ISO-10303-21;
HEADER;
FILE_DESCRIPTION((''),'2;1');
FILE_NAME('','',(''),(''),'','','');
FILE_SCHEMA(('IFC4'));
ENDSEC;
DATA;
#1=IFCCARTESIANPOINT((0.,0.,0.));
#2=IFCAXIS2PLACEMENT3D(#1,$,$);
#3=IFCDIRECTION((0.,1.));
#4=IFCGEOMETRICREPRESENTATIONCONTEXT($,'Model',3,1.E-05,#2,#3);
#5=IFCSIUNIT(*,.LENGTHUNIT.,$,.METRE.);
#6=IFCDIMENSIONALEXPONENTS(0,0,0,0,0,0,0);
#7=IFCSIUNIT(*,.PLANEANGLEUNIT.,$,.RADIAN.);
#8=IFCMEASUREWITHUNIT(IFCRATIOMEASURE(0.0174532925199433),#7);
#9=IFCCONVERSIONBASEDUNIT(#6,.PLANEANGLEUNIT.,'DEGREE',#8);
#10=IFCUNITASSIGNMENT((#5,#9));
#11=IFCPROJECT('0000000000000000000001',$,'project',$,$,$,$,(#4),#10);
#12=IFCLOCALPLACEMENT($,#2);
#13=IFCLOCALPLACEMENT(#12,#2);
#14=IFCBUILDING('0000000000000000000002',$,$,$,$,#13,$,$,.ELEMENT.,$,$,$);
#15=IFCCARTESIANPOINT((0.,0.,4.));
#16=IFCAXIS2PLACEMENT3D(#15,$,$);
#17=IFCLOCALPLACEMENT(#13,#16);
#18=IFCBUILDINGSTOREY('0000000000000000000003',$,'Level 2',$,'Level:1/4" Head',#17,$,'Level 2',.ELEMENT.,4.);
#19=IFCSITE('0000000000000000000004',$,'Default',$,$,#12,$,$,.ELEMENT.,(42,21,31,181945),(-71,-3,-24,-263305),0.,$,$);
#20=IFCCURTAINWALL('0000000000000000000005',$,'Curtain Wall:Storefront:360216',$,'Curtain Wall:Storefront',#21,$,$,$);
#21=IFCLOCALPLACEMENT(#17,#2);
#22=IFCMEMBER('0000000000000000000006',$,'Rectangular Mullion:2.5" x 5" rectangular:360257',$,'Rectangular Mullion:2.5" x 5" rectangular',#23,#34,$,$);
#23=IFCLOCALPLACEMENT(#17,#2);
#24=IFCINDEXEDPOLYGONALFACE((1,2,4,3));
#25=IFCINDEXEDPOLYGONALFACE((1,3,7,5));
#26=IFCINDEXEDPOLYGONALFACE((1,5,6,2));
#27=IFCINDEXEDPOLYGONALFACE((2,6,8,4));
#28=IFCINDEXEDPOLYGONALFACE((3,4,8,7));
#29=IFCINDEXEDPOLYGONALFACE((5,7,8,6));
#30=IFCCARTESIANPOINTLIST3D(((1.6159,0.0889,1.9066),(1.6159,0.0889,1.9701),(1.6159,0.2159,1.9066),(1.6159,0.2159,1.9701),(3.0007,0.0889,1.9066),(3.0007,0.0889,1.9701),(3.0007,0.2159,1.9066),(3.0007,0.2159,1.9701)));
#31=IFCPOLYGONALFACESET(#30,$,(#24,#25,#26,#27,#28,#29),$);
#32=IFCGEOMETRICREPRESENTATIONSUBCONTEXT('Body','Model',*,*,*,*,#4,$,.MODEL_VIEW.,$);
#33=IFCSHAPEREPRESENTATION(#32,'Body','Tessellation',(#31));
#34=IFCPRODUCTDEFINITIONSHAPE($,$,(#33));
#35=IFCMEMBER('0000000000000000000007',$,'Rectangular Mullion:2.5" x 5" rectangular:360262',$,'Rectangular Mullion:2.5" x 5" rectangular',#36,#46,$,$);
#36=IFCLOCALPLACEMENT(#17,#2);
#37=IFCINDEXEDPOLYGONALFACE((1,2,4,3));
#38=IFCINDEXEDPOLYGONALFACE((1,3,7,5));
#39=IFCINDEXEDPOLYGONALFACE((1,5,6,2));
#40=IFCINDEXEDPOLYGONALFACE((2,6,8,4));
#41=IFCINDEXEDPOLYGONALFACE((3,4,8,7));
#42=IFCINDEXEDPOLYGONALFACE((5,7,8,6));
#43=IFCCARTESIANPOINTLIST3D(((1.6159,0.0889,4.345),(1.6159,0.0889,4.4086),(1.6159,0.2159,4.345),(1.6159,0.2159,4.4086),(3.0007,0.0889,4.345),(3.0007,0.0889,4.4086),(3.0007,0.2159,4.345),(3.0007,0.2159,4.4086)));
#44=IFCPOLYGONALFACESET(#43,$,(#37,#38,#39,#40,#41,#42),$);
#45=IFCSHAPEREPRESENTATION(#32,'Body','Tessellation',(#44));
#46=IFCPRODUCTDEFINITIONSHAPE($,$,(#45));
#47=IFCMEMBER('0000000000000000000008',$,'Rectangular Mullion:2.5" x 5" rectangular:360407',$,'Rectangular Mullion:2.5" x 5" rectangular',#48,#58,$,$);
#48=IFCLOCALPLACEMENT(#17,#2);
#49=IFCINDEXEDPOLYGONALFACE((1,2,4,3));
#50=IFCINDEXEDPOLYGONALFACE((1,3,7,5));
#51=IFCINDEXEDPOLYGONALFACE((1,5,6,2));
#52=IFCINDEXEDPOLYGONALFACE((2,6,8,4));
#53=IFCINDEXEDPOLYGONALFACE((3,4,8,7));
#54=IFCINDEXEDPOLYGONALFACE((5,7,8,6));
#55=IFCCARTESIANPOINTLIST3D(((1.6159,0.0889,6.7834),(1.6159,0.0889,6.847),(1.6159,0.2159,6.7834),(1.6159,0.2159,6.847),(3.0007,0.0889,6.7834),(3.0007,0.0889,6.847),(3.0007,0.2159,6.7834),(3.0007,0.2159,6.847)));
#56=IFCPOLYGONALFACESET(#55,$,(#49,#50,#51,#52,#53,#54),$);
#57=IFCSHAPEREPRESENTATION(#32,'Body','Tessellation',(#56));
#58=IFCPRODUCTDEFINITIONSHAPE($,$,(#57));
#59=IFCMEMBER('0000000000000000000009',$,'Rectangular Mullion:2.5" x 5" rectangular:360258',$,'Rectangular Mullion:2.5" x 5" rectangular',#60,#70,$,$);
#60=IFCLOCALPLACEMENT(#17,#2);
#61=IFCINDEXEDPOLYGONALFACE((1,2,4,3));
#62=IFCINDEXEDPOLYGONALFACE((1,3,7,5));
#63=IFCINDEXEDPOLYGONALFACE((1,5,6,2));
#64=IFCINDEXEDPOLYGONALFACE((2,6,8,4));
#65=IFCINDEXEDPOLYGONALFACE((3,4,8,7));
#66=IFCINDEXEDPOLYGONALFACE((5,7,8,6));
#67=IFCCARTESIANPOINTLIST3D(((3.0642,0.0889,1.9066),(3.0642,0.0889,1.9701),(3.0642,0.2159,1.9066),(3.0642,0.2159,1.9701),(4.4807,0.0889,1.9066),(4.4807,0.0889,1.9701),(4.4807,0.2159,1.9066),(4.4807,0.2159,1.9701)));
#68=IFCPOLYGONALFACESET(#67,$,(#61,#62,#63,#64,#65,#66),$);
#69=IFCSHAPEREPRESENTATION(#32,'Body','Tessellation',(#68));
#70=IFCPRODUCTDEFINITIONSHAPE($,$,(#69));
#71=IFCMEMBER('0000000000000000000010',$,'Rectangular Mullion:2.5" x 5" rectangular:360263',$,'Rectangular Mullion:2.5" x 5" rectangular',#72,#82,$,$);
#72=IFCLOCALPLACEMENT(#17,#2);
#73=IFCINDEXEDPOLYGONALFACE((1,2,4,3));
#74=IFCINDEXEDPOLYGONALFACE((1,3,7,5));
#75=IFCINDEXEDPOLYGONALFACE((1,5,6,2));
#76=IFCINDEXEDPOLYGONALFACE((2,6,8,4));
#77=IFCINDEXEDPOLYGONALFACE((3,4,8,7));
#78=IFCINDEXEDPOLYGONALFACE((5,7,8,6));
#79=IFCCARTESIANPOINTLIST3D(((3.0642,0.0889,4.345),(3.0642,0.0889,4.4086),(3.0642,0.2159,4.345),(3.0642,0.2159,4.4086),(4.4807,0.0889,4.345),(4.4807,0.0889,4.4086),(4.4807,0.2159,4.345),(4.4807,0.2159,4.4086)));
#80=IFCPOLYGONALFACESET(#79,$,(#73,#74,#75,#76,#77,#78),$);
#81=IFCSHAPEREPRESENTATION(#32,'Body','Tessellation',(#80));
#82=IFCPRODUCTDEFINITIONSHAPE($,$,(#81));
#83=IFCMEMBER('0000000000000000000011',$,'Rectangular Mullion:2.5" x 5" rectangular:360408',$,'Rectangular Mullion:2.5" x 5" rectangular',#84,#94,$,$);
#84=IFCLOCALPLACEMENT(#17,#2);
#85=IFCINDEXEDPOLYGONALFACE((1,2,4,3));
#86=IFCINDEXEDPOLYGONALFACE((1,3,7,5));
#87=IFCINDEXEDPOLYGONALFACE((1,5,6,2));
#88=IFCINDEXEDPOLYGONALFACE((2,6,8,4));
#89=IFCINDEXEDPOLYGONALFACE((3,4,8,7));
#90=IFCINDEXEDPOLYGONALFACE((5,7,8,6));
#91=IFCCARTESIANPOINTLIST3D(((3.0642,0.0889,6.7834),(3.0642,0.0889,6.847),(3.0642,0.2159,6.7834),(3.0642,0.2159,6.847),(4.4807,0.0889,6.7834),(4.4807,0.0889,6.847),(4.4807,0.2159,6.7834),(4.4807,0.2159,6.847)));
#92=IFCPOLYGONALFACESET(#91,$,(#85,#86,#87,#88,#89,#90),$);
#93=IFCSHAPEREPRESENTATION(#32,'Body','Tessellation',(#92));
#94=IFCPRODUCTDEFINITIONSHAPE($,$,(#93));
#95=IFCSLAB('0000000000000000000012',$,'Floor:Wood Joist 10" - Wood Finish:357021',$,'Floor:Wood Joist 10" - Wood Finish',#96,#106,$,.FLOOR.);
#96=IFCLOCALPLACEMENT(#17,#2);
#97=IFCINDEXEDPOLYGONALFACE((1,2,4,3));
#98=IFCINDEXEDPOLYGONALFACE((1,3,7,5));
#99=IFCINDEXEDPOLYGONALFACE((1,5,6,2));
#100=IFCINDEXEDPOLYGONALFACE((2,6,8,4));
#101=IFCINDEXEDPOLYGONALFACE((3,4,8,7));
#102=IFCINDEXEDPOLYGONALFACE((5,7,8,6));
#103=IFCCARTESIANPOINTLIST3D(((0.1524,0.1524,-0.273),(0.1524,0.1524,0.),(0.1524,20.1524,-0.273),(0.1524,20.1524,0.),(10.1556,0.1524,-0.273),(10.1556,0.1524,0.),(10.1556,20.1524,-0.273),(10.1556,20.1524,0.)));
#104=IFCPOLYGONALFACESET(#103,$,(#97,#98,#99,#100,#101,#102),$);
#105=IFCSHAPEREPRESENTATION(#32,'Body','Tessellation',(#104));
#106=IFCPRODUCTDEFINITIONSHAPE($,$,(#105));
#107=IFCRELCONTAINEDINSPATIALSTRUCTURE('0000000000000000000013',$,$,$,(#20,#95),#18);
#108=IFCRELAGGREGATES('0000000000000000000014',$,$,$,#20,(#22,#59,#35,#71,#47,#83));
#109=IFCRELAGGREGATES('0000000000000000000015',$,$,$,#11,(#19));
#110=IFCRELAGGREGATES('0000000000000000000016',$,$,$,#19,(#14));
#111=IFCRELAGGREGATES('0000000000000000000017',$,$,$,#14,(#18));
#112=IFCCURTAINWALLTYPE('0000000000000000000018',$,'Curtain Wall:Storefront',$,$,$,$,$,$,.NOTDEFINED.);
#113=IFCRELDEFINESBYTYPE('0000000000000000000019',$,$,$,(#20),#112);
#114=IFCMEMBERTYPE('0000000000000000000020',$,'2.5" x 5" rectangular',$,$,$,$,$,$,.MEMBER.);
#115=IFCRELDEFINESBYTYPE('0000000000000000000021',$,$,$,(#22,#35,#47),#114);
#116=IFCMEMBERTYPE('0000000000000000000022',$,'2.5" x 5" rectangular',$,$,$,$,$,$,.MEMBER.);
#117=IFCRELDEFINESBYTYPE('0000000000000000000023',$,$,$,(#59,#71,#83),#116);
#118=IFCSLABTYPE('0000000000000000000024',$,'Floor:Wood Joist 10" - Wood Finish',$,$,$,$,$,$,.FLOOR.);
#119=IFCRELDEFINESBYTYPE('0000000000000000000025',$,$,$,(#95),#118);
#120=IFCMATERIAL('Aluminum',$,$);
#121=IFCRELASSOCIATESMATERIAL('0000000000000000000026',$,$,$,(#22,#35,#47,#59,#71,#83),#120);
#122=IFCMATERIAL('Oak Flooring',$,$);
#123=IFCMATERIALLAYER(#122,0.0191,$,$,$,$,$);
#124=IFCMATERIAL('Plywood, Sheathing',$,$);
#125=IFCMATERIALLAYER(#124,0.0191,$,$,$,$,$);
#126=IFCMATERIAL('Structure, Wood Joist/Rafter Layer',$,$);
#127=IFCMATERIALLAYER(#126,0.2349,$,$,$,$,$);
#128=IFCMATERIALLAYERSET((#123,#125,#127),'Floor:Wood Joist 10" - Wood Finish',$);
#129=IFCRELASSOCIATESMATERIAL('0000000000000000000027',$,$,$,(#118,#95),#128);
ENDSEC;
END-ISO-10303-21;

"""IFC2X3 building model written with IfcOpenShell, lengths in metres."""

from ifc_helpers import new_model, entity, si_unit, converted_unit, direction, frame, origin, origin_2d_with_axis, place, context, subcontext, project, spatial, rectangle, extrude, source, transform, mapped, material, layer, layer_set, layer_usage, type_object, type_shapes, element, aggregate, save


model = new_model("IFC2X3")

# Units and contexts
model_context = context("Model", 3, precision=1e-05, world=origin(), true_north=direction((0.0, 1.0)))
body_context = subcontext(model_context, "Body", "Model", "MODEL_VIEW")
ifc_project = project(units=[si_unit("LENGTHUNIT", "METRE"), converted_unit("PLANEANGLEUNIT", "DEGREE", entity("IfcRatioMeasure", 0.0174532925199433), si_unit("PLANEANGLEUNIT", "RADIAN"), dimensions=[0, 0, 0, 0, 0, 0, 0])], contexts=[model_context])

# Site, building, storey
site_placement = place(None, origin())
site = spatial("IfcSite", under=ifc_project, at=site_placement, Name="Default", CompositionType="ELEMENT", RefLatitude=(42, 21, 31, 181945), RefLongitude=(-71, -3, -24, -263305), RefElevation=0.0)
building_placement = place(site_placement, origin())
building = spatial("IfcBuilding", under=site, at=building_placement, CompositionType="ELEMENT")
storey_placement = place(building_placement, frame((0.0, 0.0, 4.0)))
storey = spatial("IfcBuildingStorey", under=building, at=storey_placement, Name="Level 2", ObjectType="Level:1/4\" Head", LongName="Level 2", CompositionType="ELEMENT", Elevation=4.0)

# Curtain wall, members
curtain_wall_type = type_object("IfcCurtainWallType", Name="Curtain Wall:Storefront", PredefinedType="NOTDEFINED")
curtain_wall_placement = place(storey_placement, frame((0.0, 0.0, -4.0)))
curtain_wall = element("IfcCurtainWall", 1, at=curtain_wall_placement, inside=storey, type_object=curtain_wall_type, Name="Curtain Wall:Storefront:360216", ObjectType="Curtain Wall:Storefront")
ifc_material_1 = material(Name="Aluminum")
member_type_1 = type_object("IfcMemberType", Name="2.5\" x 5\" rectangular", PredefinedType="MEMBER")
shared_shape_1 = source(origin(), body_context, "Body", "SweptSolid", [
    extrude(rectangle(XDim=0.127, YDim=0.0635, at=origin_2d_with_axis()), frame((0.0, 0.0, -1.3848), z_axis=(0.0, 0.0, 1.0), x_axis=(0.0, -1.0, 0.0)), (0.0, 0.0, 1.0), 1.3848),
])
type_shapes(member_type_1, [shared_shape_1])
member_1_placement = place(storey_placement, frame((3.0007, 0.1524, 1.9384), z_axis=(1.0, 0.0, 0.0), x_axis=(0.0, 0.0, 1.0)))
member_1 = element("IfcMember", 2, at=member_1_placement, type_object=member_type_1, material=ifc_material_1, Name="Rectangular Mullion:2.5\" x 5\" rectangular:360257", ObjectType="Rectangular Mullion:2.5\" x 5\" rectangular", context=body_context, shape_type="MappedRepresentation", body=[
    mapped(shared_shape_1, transform((0.0, 0.0, 0.0), scale=1.0)),
])
member_2_placement = place(storey_placement, frame((3.0007, 0.1524, 4.3768), z_axis=(1.0, 0.0, 0.0), x_axis=(0.0, 0.0, 1.0)))
member_2 = element("IfcMember", 3, at=member_2_placement, type_object=member_type_1, material=ifc_material_1, Name="Rectangular Mullion:2.5\" x 5\" rectangular:360262", ObjectType="Rectangular Mullion:2.5\" x 5\" rectangular", context=body_context, shape_type="MappedRepresentation", body=[
    mapped(shared_shape_1, transform((0.0, 0.0, 0.0), scale=1.0)),
])
member_3_placement = place(storey_placement, frame((3.0007, 0.1524, 6.8152), z_axis=(1.0, 0.0, 0.0), x_axis=(0.0, 0.0, 1.0)))
member_3 = element("IfcMember", 4, at=member_3_placement, type_object=member_type_1, material=ifc_material_1, Name="Rectangular Mullion:2.5\" x 5\" rectangular:360407", ObjectType="Rectangular Mullion:2.5\" x 5\" rectangular", context=body_context, shape_type="MappedRepresentation", body=[
    mapped(shared_shape_1, transform((0.0, 0.0, 0.0), scale=1.0)),
])
member_type_2 = type_object("IfcMemberType", Name="2.5\" x 5\" rectangular", PredefinedType="MEMBER")
shared_shape_2 = source(origin(), body_context, "Body", "SweptSolid", [
    extrude(rectangle(XDim=0.127, YDim=0.0635, at=origin_2d_with_axis()), frame((0.0, 0.0, -1.4165), z_axis=(0.0, 0.0, 1.0), x_axis=(0.0, -1.0, 0.0)), (0.0, 0.0, 1.0), 1.4165),
])
type_shapes(member_type_2, [shared_shape_2])
member_4_placement = place(storey_placement, frame((4.4807, 0.1524, 1.9384), z_axis=(1.0, 0.0, 0.0), x_axis=(0.0, 0.0, 1.0)))
member_4 = element("IfcMember", 5, at=member_4_placement, type_object=member_type_2, material=ifc_material_1, Name="Rectangular Mullion:2.5\" x 5\" rectangular:360258", ObjectType="Rectangular Mullion:2.5\" x 5\" rectangular", context=body_context, shape_type="MappedRepresentation", body=[
    mapped(shared_shape_2, transform((0.0, 0.0, 0.0), scale=1.0)),
])
member_5_placement = place(storey_placement, frame((4.4807, 0.1524, 4.3768), z_axis=(1.0, 0.0, 0.0), x_axis=(0.0, 0.0, 1.0)))
member_5 = element("IfcMember", 6, at=member_5_placement, type_object=member_type_2, material=ifc_material_1, Name="Rectangular Mullion:2.5\" x 5\" rectangular:360263", ObjectType="Rectangular Mullion:2.5\" x 5\" rectangular", context=body_context, shape_type="MappedRepresentation", body=[
    mapped(shared_shape_2, transform((0.0, 0.0, 0.0), scale=1.0)),
])
member_6_placement = place(storey_placement, frame((4.4807, 0.1524, 6.8152), z_axis=(1.0, 0.0, 0.0), x_axis=(0.0, 0.0, 1.0)))
member_6 = element("IfcMember", 7, at=member_6_placement, type_object=member_type_2, material=ifc_material_1, Name="Rectangular Mullion:2.5\" x 5\" rectangular:360408", ObjectType="Rectangular Mullion:2.5\" x 5\" rectangular", context=body_context, shape_type="MappedRepresentation", body=[
    mapped(shared_shape_2, transform((0.0, 0.0, 0.0), scale=1.0)),
])

# Slab
ifc_material_2 = material(Name="Oak Flooring")
ifc_layer_1 = layer(ifc_material_2, 0.0191)
ifc_material_3 = material(Name="Plywood, Sheathing")
ifc_layer_2 = layer(ifc_material_3, 0.0191)
ifc_material_4 = material(Name="Structure, Wood Joist/Rafter Layer")
ifc_layer_3 = layer(ifc_material_4, 0.2349)
ifc_layer_set_1 = layer_set([ifc_layer_1, ifc_layer_2, ifc_layer_3], Name="Floor:Wood Joist 10\" - Wood Finish")
ifc_layer_usage_1 = layer_usage(ifc_layer_set_1, "AXIS3", "POSITIVE", 0.0)
slab_type = type_object("IfcSlabType", Name="Floor:Wood Joist 10\" - Wood Finish", PredefinedType="FLOOR", material=ifc_layer_set_1)
slab_placement = place(storey_placement, origin())
element("IfcSlab", 8, at=slab_placement, inside=storey, type_object=slab_type, material=ifc_layer_usage_1, Name="Floor:Wood Joist 10\" - Wood Finish:357021", ObjectType="Floor:Wood Joist 10\" - Wood Finish", PredefinedType="FLOOR", context=body_context, shape_type="SweptSolid", body=[
    extrude(rectangle(XDim=20.0, YDim=10.0032, at=origin_2d_with_axis()), frame((5.154, 10.1524, 0.0), z_axis=(0.0, 0.0, -1.0), x_axis=(0.0, 1.0, 0.0)), (0.0, 0.0, 1.0), 0.2731),
])

aggregate(curtain_wall, [member_1, member_4, member_2, member_5, member_3, member_6])

save(model, "model.ifc")
